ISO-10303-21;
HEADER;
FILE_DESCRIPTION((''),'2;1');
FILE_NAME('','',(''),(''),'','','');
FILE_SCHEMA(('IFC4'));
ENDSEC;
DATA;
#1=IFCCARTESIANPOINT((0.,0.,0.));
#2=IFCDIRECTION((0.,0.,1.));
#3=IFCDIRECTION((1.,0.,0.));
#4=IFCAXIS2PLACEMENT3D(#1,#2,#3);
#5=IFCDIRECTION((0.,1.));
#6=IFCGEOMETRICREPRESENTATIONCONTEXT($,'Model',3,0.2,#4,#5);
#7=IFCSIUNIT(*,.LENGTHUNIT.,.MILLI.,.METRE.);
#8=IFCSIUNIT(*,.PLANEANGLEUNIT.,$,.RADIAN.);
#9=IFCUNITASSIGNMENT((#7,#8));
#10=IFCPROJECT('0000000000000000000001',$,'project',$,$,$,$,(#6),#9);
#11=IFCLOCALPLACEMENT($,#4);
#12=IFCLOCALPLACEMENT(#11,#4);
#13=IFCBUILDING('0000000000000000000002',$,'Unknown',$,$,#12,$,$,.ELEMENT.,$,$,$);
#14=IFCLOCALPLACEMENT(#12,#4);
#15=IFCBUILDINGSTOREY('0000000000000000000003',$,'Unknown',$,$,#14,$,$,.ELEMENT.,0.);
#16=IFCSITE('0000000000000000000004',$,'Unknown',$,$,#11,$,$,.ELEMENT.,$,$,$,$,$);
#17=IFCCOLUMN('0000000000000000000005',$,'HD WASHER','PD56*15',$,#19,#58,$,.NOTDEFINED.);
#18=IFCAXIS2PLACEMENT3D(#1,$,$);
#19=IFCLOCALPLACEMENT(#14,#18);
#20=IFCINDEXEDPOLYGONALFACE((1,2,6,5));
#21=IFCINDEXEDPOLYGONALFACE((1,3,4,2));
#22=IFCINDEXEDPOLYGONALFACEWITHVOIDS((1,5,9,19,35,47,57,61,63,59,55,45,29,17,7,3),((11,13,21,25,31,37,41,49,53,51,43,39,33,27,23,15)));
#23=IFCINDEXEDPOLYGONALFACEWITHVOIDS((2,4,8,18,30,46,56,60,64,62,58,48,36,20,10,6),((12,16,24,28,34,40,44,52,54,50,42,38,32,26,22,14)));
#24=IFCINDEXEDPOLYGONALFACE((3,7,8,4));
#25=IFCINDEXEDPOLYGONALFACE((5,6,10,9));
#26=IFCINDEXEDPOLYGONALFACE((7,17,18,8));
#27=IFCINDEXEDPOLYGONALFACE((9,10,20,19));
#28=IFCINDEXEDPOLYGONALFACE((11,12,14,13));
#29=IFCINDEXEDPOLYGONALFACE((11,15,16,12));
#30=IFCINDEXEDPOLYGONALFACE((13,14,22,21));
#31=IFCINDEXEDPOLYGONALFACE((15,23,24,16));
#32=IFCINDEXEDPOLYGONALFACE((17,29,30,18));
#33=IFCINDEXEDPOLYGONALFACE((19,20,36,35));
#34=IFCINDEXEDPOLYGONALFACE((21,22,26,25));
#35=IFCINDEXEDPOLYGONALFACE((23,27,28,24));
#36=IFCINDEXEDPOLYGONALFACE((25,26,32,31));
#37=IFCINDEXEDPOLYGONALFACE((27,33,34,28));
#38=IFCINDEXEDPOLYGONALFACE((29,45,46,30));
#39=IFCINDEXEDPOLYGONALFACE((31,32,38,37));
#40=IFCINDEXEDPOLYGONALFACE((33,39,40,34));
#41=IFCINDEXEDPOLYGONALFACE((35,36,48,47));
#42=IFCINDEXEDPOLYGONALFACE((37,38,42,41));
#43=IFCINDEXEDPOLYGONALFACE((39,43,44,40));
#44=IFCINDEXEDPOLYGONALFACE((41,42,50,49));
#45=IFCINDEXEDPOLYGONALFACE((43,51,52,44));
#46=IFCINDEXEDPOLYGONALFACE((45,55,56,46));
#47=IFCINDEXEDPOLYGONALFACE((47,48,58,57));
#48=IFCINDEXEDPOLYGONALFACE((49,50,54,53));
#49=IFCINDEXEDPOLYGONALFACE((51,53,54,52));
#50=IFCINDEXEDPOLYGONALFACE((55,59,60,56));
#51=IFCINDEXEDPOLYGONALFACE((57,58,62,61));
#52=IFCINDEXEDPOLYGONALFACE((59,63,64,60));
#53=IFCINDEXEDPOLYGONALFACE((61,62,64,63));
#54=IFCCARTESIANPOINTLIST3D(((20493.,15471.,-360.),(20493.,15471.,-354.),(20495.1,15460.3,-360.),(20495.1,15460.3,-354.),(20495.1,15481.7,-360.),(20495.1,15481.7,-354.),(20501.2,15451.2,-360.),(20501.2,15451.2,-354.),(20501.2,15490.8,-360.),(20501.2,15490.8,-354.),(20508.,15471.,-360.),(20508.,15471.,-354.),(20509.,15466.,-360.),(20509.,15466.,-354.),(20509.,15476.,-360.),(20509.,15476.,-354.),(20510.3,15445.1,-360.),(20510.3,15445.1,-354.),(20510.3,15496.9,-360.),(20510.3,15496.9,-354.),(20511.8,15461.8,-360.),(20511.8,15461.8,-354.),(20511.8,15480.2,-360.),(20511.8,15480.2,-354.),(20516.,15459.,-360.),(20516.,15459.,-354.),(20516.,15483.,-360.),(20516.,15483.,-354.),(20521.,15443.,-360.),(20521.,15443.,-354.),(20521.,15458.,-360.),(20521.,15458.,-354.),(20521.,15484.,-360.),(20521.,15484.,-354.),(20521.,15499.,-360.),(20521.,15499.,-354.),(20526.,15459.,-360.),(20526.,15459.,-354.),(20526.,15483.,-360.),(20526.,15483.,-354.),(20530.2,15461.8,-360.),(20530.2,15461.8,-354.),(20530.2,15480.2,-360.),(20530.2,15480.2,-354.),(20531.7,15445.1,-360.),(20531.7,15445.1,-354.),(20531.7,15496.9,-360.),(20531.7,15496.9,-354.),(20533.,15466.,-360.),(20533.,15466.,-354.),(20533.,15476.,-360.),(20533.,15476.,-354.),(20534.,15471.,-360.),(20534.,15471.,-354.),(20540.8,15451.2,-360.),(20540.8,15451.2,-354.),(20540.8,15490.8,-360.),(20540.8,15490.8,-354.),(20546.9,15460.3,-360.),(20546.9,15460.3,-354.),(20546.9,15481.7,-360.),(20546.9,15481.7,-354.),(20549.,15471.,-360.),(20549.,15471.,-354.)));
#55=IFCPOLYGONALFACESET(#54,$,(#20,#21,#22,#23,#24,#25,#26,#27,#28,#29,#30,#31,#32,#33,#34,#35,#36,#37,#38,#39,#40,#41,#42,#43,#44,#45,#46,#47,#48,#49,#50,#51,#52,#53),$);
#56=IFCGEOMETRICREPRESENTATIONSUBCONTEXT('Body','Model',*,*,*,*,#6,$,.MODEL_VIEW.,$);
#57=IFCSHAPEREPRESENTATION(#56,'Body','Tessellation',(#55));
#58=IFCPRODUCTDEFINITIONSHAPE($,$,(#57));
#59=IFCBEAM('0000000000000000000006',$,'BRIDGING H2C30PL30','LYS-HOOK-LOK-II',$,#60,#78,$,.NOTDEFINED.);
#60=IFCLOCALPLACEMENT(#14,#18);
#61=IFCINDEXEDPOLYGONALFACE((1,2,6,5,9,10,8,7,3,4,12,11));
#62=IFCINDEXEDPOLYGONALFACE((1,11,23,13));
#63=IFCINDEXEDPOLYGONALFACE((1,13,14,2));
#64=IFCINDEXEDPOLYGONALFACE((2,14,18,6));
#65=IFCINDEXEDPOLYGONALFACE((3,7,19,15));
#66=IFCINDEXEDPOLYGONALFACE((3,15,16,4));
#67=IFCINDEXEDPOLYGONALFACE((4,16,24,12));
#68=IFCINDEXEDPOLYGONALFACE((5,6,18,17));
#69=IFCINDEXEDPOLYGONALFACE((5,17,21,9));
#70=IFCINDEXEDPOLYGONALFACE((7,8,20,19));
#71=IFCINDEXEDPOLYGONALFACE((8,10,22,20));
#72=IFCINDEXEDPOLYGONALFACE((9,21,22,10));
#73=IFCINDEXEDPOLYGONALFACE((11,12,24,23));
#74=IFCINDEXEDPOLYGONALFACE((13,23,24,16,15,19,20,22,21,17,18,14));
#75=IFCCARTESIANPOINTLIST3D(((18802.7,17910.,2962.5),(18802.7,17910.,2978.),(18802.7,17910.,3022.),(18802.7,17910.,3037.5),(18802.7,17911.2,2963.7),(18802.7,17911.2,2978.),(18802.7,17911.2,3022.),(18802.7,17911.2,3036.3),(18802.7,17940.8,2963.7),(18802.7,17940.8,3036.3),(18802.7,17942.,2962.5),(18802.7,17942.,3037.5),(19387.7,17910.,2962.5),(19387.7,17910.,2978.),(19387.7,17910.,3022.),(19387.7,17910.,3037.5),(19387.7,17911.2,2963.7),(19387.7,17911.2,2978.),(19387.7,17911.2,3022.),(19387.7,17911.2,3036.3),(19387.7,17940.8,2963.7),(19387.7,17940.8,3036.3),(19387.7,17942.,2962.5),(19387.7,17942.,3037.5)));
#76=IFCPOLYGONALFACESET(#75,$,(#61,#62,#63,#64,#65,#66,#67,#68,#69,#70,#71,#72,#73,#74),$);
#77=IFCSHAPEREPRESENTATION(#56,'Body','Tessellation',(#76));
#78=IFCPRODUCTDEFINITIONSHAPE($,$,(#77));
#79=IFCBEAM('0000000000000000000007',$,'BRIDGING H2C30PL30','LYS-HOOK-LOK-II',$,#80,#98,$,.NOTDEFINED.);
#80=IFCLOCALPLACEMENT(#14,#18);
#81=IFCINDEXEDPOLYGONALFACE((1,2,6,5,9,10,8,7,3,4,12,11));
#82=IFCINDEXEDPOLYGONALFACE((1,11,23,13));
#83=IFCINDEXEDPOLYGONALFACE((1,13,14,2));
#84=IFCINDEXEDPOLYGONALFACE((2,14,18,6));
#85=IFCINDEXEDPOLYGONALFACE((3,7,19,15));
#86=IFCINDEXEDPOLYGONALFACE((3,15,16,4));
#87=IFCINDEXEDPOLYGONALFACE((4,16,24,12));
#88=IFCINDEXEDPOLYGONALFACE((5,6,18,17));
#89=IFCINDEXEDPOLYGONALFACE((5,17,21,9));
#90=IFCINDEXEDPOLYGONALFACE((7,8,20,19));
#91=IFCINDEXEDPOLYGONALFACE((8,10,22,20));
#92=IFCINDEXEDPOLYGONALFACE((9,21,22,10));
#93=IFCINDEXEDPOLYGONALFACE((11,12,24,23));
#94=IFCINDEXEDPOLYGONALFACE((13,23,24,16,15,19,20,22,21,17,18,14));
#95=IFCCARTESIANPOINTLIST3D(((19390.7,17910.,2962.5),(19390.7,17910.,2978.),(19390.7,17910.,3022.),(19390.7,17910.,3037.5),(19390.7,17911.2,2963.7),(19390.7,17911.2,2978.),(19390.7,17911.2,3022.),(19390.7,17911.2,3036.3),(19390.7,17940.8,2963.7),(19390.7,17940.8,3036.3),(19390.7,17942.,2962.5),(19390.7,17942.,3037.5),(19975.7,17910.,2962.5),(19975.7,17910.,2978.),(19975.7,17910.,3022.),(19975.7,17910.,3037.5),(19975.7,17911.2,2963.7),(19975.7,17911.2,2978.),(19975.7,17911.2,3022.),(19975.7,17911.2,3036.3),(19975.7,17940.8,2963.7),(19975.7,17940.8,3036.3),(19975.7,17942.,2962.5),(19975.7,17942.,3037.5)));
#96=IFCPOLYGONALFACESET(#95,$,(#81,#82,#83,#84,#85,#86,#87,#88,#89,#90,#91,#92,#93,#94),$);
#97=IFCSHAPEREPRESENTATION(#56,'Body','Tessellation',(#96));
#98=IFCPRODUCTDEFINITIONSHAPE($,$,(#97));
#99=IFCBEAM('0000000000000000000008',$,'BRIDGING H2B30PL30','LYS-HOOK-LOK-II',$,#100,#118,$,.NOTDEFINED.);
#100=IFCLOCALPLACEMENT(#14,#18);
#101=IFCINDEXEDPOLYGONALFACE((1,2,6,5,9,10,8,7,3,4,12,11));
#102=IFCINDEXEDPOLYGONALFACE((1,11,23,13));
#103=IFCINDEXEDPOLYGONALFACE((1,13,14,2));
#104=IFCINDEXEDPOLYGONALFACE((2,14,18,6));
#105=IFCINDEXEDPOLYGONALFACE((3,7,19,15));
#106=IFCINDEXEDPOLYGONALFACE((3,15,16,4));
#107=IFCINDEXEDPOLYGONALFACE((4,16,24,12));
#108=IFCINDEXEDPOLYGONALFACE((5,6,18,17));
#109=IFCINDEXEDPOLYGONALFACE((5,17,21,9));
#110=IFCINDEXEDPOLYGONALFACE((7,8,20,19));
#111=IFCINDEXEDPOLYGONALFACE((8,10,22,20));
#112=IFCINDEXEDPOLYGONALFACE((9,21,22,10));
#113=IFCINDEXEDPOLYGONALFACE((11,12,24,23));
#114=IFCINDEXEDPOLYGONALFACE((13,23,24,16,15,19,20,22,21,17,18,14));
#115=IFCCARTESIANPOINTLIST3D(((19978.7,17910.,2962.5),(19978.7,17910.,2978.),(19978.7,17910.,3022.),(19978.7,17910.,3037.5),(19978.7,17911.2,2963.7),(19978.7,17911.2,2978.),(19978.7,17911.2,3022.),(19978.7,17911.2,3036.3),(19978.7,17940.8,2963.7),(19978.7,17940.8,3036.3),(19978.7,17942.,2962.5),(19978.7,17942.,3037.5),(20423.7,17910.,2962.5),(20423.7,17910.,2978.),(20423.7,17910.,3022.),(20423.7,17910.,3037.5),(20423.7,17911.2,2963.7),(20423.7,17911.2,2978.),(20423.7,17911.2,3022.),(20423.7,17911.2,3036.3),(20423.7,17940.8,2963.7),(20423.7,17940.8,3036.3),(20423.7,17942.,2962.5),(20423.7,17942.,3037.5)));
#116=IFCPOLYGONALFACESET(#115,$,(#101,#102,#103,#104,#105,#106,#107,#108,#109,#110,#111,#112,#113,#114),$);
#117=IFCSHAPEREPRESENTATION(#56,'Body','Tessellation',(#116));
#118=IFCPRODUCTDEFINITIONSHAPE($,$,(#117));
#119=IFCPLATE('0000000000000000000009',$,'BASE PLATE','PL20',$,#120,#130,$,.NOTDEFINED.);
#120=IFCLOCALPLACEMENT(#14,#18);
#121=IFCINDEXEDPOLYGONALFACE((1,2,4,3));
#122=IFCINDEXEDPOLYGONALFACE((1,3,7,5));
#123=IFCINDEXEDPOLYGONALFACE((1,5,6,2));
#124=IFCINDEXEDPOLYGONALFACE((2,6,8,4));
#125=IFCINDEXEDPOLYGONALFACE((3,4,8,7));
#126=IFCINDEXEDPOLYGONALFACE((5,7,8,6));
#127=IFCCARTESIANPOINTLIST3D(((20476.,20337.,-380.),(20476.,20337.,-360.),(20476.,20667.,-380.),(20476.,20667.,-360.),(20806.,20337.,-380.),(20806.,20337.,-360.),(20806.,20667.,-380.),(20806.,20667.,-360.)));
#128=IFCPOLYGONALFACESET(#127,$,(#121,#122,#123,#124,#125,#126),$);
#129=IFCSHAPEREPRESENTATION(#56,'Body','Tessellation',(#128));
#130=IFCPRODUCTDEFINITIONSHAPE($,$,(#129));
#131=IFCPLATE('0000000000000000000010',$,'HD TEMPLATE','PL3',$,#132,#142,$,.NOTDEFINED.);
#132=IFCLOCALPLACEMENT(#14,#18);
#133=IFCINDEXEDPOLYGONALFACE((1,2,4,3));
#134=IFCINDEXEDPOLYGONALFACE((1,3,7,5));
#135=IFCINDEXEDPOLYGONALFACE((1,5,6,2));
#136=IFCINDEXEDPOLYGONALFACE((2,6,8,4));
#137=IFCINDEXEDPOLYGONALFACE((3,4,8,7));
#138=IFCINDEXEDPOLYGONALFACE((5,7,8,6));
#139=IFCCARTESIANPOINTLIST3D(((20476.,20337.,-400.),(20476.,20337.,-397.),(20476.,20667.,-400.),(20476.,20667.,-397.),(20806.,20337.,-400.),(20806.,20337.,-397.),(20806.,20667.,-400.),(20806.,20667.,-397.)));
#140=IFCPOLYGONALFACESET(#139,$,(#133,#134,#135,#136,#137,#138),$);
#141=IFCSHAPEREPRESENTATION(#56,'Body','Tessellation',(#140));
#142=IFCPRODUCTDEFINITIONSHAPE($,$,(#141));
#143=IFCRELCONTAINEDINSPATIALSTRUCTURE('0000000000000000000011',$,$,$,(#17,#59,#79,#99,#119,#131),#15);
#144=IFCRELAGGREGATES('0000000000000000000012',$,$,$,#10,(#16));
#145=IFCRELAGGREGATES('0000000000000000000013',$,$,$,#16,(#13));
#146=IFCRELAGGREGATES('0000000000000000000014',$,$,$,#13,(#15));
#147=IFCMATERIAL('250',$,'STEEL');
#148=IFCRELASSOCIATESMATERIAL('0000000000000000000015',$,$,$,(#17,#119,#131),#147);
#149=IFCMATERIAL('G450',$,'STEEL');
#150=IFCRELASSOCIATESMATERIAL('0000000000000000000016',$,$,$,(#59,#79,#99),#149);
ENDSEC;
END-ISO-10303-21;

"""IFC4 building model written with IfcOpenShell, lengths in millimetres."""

from ifc_helpers import new_model, si_unit, direction, frame, origin_with_axes, place, context, subcontext, project, spatial, line, indexed_curve, outline, extrude, material, element, save


model = new_model("IFC4")

# Units and contexts
model_context = context("Model", 3, precision=0.2, world=origin_with_axes(), true_north=direction((0.0, 1.0)))
body_context = subcontext(model_context, "Body", "Model", "MODEL_VIEW")
ifc_project = project(units=[si_unit("LENGTHUNIT", "METRE", prefix="MILLI"), si_unit("PLANEANGLEUNIT", "RADIAN")], contexts=[model_context])

# Site, building, storey
site_placement = place(None, origin_with_axes())
site = spatial("IfcSite", under=ifc_project, at=site_placement, Name="Unknown", CompositionType="ELEMENT")
building_placement = place(site_placement, origin_with_axes())
building = spatial("IfcBuilding", under=site, at=building_placement, Name="Unknown", CompositionType="ELEMENT")
storey_placement = place(building_placement, origin_with_axes())
storey = spatial("IfcBuildingStorey", under=building, at=storey_placement, Name="Unknown", CompositionType="ELEMENT", Elevation=0.0)

# Column
ifc_material_1 = material(Name="250", Category="STEEL")
column_1_placement = place(storey_placement, frame((20521.0, 15471.0, -360.0), z_axis=(-1.0, 0.0, 0.0), x_axis=(0.0, 0.0, 1.0)))
element("IfcColumn", 1, at=column_1_placement, inside=storey, material=ifc_material_1, Name="HD WASHER", Description="PD56*15", PredefinedType="NOTDEFINED", context=body_context, shape_type="SolidModel", body=[
    extrude(outline(indexed_curve([(28.0, 0.0), (25.9, 10.7), (19.8, 19.8), (10.7, 25.9), (0.0, 28.0), (-10.7, 25.9), (-19.8, 19.8), (-25.9, 10.7), (-28.0, 0.0), (-25.9, -10.7), (-19.8, -19.8), (-10.7, -25.9), (0.0, -28.0), (10.7, -25.9), (19.8, -19.8), (25.9, -10.7)], segments=[line(1, 2, 3, 4, 5, 6, 7, 8, 9, 10, 11, 12, 13, 14, 15, 16, 1)]), holes=[indexed_curve([(13.0, 0.0), (12.0, -5.0), (9.2, -9.2), (5.0, -12.0), (0.0, -13.0), (-5.0, -12.0), (-9.2, -9.2), (-12.0, -5.0), (-13.0, 0.0), (-12.0, 5.0), (-9.2, 9.2), (-5.0, 12.0), (0.0, 13.0), (5.0, 12.0), (9.2, 9.2), (12.0, 5.0)], segments=[line(1, 2, 3, 4, 5, 6, 7, 8, 9, 10, 11, 12, 13, 14, 15, 16, 1)])]), frame((0.0, 0.0, 0.0), z_axis=(-1.0, 0.0, 0.0), x_axis=(0.0, 0.0, 1.0)), (0.0, 0.0, -1.0), 6.0),
])

# Beams
ifc_material_2 = material(Name="G450", Category="STEEL")
for number, where, z_axis, x_axis, name in (
    (2, (18802.7, 17926.0, 3000.0), (0.0, -1.0, 0.0), (1.0, 0.0, 0.0), "BRIDGING H2C30PL30"),
    (3, (19390.7, 17926.0, 3000.0), (0.0, -1.0, 0.0), (1.0, 0.0, 0.0), "BRIDGING H2C30PL30"),
):
    element("IfcBeam", number, at=place(storey_placement, frame(where, z_axis=z_axis, x_axis=x_axis)), inside=storey, material=ifc_material_2, Name=name, Description="LYS-HOOK-LOK-II", PredefinedType="NOTDEFINED", context=body_context, shape_type="SolidModel", body=[
        extrude(outline(indexed_curve([(16.0, -37.5), (16.0, -22.0), (14.8, -22.0), (14.8, -36.3), (-14.8, -36.3), (-14.8, 36.3), (14.8, 36.3), (14.8, 22.0), (16.0, 22.0), (16.0, 37.5), (-16.0, 37.5), (-16.0, -37.5)], segments=[line(1, 2, 3, 4, 5, 6, 7, 8, 9, 10, 11, 12, 1)])), frame((0.0, 0.0, 0.0), z_axis=(-1.0, 0.0, 0.0), x_axis=(0.0, 0.0, 1.0)), (0.0, 0.0, -1.0), 585.0),
    ])
beam_1_placement = place(storey_placement, frame((19978.7, 17926.0, 3000.0), z_axis=(0.0, -1.0, 0.0), x_axis=(1.0, 0.0, 0.0)))
element("IfcBeam", 4, at=beam_1_placement, inside=storey, material=ifc_material_2, Name="BRIDGING H2B30PL30", Description="LYS-HOOK-LOK-II", PredefinedType="NOTDEFINED", context=body_context, shape_type="SolidModel", body=[
    extrude(outline(indexed_curve([(16.0, -37.5), (16.0, -22.0), (14.8, -22.0), (14.8, -36.3), (-14.8, -36.3), (-14.8, 36.3), (14.8, 36.3), (14.8, 22.0), (16.0, 22.0), (16.0, 37.5), (-16.0, 37.5), (-16.0, -37.5)], segments=[line(1, 2, 3, 4, 5, 6, 7, 8, 9, 10, 11, 12, 1)])), frame((0.0, 0.0, 0.0), z_axis=(-1.0, 0.0, 0.0), x_axis=(0.0, 0.0, 1.0)), (0.0, 0.0, -1.0), 445.0),
])

# Plates
plate_1_placement = place(storey_placement, frame((20476.0, 20337.0, -370.0), z_axis=(0.0, 0.0, 1.0), x_axis=(1.0, 0.0, 0.0)))
element("IfcPlate", 5, at=plate_1_placement, inside=storey, material=ifc_material_1, Name="BASE PLATE", Description="PL20", PredefinedType="NOTDEFINED", context=body_context, shape_type="SolidModel", body=[
    extrude(outline(indexed_curve([(0.0, 0.0), (330.0, 0.0), (330.0, 330.0), (0.0, 330.0)], segments=[line(1, 2, 3, 4, 1)])), frame((0.0, 0.0, 10.0), z_axis=(0.0, 0.0, 1.0), x_axis=(1.0, 0.0, 0.0)), (0.0, 0.0, -1.0), 20.0),
])
plate_2_placement = place(storey_placement, frame((20476.0, 20337.0, -398.5), z_axis=(0.0, 0.0, 1.0), x_axis=(1.0, 0.0, 0.0)))
element("IfcPlate", 6, at=plate_2_placement, inside=storey, material=ifc_material_1, Name="HD TEMPLATE", Description="PL3", PredefinedType="NOTDEFINED", context=body_context, shape_type="SolidModel", body=[
    extrude(outline(indexed_curve([(0.0, 0.0), (330.0, 0.0), (330.0, 330.0), (0.0, 330.0)], segments=[line(1, 2, 3, 4, 1)])), frame((0.0, 0.0, 1.5), z_axis=(0.0, 0.0, 1.0), x_axis=(1.0, 0.0, 0.0)), (0.0, 0.0, -1.0), 3.0),
])

save(model, "model.ifc")
